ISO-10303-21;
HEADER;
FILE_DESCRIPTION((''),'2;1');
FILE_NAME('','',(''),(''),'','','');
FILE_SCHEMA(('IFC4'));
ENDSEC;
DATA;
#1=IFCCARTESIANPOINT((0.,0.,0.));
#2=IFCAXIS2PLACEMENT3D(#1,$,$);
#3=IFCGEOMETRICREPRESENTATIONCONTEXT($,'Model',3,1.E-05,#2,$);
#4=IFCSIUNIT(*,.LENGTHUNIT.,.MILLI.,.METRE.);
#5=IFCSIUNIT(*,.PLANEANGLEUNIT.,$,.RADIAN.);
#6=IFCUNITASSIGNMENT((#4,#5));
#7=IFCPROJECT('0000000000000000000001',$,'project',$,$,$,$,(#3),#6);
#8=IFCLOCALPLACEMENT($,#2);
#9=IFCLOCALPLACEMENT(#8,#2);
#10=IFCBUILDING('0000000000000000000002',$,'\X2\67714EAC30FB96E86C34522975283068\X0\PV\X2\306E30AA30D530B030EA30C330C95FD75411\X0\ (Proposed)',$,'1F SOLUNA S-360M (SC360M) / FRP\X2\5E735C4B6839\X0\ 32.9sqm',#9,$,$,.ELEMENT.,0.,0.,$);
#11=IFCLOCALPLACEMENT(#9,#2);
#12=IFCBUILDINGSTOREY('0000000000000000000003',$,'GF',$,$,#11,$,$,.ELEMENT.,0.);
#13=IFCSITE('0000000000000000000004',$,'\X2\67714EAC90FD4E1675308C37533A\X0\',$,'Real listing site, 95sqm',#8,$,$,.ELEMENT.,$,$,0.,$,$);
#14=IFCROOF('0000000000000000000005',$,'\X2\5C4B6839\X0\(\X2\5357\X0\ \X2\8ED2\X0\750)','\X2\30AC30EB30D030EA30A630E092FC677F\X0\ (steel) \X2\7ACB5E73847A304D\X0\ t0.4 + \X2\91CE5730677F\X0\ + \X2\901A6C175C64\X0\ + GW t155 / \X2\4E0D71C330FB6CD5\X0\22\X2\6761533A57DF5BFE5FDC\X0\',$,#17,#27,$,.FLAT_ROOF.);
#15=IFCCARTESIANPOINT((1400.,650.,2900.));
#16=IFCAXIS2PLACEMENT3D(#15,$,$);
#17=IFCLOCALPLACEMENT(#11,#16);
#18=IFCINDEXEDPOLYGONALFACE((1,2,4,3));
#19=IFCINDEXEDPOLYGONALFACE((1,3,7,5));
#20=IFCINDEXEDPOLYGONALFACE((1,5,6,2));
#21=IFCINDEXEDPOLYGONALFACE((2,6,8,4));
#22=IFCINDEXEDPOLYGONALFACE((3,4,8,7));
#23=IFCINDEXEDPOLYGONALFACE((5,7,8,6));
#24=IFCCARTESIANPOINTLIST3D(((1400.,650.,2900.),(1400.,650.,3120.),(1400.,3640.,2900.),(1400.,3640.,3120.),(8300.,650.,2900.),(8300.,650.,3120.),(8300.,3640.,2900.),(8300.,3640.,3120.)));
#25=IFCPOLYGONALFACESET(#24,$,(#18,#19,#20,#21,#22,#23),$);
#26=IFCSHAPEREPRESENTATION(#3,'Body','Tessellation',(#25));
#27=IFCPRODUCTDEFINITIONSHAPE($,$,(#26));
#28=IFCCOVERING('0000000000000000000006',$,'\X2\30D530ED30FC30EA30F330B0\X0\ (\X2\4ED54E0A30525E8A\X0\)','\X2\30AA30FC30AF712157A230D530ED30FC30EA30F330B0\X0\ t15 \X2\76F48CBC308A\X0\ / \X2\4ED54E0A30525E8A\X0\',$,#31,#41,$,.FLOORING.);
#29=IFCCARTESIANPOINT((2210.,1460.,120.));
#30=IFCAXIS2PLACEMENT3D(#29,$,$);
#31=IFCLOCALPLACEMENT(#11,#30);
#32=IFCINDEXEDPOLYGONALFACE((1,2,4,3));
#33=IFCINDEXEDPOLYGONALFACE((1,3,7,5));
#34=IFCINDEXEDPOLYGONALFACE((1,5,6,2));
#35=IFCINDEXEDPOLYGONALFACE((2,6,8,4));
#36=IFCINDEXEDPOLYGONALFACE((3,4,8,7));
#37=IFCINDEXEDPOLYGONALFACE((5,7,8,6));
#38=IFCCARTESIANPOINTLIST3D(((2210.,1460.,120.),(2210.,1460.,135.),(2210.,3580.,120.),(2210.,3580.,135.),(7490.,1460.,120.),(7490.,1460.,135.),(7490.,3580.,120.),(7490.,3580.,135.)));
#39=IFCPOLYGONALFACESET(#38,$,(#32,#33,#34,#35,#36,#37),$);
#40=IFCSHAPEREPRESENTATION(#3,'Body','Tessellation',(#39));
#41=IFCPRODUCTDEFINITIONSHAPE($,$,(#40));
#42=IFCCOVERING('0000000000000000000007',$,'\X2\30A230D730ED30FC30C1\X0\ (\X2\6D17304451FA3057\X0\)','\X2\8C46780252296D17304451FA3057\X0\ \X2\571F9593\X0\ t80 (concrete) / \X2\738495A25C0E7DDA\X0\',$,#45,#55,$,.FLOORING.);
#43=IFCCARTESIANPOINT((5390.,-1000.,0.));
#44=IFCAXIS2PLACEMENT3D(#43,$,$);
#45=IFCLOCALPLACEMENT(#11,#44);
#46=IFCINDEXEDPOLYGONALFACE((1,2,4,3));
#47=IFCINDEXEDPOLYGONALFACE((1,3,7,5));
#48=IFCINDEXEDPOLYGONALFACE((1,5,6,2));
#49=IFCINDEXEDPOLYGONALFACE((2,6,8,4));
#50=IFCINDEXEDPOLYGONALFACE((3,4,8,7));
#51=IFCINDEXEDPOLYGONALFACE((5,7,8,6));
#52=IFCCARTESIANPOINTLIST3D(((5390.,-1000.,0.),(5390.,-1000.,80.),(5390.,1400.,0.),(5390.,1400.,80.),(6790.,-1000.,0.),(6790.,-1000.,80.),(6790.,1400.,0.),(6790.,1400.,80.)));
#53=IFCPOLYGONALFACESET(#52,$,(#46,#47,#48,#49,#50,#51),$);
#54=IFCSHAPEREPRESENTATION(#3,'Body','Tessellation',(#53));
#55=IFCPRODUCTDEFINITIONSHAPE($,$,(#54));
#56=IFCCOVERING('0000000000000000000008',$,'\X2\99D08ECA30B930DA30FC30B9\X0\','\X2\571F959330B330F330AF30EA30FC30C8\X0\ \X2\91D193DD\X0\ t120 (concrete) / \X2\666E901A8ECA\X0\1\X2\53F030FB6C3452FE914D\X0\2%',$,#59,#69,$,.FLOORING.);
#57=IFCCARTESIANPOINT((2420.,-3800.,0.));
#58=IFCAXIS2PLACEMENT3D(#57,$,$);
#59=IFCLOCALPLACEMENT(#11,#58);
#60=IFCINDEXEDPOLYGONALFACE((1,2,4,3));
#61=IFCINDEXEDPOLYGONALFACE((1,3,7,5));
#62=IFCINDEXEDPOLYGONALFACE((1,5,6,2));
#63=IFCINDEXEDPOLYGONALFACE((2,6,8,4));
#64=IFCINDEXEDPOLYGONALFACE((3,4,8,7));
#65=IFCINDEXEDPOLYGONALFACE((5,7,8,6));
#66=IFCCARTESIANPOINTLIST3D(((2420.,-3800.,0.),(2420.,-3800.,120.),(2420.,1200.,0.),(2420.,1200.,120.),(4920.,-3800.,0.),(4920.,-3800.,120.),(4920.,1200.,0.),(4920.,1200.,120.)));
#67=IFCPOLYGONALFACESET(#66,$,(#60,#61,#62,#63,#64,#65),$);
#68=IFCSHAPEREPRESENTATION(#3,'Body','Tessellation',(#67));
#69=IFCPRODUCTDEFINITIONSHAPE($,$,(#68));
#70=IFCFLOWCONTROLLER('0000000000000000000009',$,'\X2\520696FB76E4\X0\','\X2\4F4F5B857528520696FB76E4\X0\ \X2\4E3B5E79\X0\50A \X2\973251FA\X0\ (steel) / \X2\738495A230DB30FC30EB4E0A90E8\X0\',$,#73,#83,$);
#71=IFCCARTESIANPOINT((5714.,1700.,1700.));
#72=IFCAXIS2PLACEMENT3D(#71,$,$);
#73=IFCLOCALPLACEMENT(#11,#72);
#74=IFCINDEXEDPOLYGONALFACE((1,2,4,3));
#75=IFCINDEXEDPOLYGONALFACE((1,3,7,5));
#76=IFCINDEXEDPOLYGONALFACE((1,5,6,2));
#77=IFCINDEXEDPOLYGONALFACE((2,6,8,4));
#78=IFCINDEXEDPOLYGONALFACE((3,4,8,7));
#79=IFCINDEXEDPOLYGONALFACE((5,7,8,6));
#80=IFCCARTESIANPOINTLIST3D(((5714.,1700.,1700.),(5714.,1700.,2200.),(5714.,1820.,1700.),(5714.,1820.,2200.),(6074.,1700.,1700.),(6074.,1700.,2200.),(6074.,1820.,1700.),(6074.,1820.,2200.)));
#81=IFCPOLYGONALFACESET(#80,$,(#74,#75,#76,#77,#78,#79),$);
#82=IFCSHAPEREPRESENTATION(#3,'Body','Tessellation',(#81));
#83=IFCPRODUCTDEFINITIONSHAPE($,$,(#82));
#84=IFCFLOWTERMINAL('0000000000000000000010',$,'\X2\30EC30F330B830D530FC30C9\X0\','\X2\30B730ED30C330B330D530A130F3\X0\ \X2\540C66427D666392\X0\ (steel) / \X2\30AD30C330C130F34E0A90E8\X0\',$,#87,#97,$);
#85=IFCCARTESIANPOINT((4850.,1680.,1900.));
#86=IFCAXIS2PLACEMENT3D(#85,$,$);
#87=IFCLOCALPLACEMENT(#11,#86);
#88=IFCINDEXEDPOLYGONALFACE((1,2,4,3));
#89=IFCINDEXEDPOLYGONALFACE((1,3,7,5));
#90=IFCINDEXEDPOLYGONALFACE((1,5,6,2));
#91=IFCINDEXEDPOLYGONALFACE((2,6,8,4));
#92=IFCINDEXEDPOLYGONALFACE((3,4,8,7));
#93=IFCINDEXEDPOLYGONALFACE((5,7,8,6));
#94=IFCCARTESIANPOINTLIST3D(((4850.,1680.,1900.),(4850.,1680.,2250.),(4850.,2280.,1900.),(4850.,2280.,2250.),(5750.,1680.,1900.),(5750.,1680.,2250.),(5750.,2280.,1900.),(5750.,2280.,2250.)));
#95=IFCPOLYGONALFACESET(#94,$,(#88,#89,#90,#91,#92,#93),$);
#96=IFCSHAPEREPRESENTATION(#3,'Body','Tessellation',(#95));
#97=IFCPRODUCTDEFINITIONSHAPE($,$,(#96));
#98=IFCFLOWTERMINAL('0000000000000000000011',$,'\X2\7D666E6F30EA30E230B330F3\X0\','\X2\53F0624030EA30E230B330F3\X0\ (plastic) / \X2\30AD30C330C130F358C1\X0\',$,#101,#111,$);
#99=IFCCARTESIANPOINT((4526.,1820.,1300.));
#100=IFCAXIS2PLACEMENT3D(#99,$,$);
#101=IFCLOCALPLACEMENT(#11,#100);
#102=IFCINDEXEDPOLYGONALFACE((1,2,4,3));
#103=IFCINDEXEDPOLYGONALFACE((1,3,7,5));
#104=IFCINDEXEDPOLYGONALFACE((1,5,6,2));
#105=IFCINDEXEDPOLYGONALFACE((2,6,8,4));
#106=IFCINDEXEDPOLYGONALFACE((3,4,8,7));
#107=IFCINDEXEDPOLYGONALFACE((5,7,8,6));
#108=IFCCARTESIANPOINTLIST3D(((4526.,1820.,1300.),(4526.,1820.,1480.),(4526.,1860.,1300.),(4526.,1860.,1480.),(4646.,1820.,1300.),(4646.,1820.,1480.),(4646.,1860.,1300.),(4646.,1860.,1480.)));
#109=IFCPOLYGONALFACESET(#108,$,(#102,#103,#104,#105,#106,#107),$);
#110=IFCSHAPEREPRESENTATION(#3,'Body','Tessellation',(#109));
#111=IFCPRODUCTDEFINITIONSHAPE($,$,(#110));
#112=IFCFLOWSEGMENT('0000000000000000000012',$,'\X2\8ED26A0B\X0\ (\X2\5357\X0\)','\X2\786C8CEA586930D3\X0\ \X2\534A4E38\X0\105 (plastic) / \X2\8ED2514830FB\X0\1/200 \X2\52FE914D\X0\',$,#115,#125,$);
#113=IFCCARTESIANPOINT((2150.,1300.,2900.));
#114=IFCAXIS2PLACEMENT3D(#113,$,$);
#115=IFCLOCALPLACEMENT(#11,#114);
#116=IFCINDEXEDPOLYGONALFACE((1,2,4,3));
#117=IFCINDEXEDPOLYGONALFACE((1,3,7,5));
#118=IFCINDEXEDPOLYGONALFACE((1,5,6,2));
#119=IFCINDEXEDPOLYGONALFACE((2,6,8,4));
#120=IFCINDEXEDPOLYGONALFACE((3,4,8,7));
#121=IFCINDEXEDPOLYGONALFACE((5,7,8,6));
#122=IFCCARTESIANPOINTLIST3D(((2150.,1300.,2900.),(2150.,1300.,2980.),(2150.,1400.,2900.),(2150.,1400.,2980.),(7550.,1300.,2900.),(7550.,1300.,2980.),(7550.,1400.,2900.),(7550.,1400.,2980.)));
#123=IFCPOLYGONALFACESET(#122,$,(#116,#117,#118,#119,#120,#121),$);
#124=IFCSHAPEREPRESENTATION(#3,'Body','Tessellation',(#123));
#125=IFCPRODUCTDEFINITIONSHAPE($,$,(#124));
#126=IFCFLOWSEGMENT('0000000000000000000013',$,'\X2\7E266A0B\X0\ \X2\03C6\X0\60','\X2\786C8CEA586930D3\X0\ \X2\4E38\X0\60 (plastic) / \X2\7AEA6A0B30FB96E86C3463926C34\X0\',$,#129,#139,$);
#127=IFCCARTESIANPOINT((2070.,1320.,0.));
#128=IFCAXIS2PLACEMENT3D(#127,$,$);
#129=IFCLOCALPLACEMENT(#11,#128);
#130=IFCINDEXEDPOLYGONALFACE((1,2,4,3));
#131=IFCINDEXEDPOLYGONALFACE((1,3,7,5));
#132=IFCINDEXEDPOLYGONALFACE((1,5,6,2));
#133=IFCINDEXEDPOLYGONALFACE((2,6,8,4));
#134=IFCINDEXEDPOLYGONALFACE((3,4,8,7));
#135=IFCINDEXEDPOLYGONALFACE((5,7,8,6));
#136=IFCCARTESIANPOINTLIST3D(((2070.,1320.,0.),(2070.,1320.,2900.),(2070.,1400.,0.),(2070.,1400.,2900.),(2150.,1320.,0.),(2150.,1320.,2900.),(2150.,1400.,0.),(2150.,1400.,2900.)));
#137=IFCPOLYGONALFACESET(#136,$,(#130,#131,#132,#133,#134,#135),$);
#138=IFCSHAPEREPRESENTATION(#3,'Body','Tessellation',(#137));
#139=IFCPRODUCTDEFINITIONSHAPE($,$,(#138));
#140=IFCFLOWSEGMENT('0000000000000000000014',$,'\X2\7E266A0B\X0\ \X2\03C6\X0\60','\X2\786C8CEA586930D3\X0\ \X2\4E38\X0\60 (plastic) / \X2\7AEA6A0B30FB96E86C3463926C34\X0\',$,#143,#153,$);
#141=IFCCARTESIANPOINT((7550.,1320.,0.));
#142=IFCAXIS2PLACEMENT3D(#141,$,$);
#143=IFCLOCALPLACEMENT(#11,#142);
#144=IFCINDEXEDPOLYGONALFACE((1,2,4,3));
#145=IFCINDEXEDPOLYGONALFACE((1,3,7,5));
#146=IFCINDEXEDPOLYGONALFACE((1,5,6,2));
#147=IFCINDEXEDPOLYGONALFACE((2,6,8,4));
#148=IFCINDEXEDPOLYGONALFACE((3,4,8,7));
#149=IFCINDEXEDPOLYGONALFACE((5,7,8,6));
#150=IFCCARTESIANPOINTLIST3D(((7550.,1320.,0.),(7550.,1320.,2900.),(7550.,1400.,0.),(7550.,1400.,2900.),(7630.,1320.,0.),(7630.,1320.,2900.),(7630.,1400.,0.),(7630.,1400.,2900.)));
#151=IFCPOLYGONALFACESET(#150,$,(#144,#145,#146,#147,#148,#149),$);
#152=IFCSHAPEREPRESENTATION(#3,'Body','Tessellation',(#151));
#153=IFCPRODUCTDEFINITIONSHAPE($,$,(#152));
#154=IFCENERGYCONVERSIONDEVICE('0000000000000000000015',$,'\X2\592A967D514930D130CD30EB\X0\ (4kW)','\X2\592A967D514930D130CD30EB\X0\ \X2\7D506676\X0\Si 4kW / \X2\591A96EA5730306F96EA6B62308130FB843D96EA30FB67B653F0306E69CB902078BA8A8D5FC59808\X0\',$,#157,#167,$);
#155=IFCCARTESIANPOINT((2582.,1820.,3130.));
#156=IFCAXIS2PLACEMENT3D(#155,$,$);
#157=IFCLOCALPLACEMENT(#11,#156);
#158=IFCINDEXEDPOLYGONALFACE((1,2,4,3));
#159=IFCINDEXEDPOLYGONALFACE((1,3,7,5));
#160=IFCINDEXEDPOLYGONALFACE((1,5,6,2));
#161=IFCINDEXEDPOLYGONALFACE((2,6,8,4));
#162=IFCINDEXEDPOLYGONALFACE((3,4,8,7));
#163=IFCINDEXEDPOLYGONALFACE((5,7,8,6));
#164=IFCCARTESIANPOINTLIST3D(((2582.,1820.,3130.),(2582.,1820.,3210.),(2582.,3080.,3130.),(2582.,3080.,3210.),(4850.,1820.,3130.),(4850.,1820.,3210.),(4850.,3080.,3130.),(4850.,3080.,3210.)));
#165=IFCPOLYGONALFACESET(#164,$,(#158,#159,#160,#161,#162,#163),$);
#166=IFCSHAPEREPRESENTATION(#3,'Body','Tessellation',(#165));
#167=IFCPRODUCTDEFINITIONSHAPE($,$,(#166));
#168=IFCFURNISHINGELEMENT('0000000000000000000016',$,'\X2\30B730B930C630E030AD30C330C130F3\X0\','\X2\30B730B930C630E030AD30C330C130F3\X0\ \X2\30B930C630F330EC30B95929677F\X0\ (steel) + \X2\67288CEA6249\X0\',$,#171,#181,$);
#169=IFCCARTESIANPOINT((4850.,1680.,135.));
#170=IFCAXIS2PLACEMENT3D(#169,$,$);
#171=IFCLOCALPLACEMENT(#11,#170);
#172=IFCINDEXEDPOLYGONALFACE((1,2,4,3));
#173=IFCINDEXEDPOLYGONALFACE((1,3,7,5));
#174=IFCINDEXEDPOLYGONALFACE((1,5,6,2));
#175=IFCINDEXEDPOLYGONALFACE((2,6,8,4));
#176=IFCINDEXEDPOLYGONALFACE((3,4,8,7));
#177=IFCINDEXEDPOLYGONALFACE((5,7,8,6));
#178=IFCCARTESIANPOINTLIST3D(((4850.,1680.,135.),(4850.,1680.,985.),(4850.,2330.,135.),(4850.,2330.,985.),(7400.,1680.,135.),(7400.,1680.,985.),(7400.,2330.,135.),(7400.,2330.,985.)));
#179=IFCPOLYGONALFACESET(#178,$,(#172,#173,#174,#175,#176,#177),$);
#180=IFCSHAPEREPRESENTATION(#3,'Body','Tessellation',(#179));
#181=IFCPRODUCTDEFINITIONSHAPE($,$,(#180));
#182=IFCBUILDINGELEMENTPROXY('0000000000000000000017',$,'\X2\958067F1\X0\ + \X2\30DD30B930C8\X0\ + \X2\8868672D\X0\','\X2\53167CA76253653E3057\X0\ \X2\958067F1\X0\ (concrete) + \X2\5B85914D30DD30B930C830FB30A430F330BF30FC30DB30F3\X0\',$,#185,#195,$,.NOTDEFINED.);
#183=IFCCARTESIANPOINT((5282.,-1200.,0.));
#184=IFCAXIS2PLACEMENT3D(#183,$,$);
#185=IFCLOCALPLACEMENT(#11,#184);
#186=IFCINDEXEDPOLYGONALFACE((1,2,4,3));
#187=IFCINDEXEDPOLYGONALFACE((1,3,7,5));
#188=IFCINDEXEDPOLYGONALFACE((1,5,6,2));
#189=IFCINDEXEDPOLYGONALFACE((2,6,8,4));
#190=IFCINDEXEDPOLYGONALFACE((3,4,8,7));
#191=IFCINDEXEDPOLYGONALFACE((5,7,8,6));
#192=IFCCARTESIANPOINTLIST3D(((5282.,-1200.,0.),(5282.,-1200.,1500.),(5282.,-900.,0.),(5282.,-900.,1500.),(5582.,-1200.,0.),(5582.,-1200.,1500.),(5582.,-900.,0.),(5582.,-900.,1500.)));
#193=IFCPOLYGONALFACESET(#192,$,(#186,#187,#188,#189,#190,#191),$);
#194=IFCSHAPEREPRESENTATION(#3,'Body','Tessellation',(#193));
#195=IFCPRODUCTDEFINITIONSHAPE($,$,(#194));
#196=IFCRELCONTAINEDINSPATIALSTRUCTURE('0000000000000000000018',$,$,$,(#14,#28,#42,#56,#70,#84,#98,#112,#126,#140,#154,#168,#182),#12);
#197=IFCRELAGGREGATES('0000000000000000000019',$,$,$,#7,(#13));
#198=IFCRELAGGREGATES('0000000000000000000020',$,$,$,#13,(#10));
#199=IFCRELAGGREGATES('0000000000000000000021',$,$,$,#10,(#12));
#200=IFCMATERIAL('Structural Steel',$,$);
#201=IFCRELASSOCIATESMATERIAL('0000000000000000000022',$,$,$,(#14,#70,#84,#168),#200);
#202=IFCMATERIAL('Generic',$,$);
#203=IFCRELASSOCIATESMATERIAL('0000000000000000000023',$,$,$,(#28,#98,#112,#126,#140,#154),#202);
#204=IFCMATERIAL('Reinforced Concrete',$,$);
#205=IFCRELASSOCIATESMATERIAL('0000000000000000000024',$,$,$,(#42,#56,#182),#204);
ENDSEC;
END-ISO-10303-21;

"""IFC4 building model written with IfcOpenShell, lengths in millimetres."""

from ifc_helpers import new_model, si_unit, frame, frame_2d, origin, place, context, project, spatial, rectangle, extrude, material, element, save


model = new_model("IFC4")

# Units and contexts
model_context = context("Model", 3, precision=1e-05, world=origin())
ifc_project = project(units=[si_unit("LENGTHUNIT", "METRE", prefix="MILLI"), si_unit("PLANEANGLEUNIT", "RADIAN")], contexts=[model_context])

# Site, building, storey
site_placement = place(None, origin())
site = spatial("IfcSite", under=ifc_project, at=site_placement, Name="東京都世田谷区", ObjectType="Real listing site, 95sqm", CompositionType="ELEMENT", RefElevation=0.0)
building_placement = place(site_placement, origin())
building = spatial("IfcBuilding", under=site, at=building_placement, Name="東京・雨水利用とPVのオフグリッド志向 (Proposed)", ObjectType="1F SOLUNA S-360M (SC360M) / FRP平屋根 32.9sqm", CompositionType="ELEMENT", ElevationOfRefHeight=0.0, ElevationOfTerrain=0.0)
storey_placement = place(building_placement, origin())
storey = spatial("IfcBuildingStorey", under=building, at=storey_placement, Name="GF", CompositionType="ELEMENT", Elevation=0.0)

# Shared definitions
ifc_material_1 = material(Name="Reinforced Concrete")

# Roof
ifc_material_2 = material(Name="Structural Steel")
roof_placement = place(storey_placement, frame((1400.0, 650.0, 2900.0)))
element("IfcRoof", 1, at=roof_placement, inside=storey, material=ifc_material_2, Name="屋根(南 軒750)", Description="ガルバリウム鋼板 (steel) 立平葺き t0.4 + 野地板 + 通気層 + GW t155 / 不燃・法22条区域対応", PredefinedType="FLAT_ROOF", context=model_context, shape_type="SweptSolid", body=[
    extrude(rectangle(XDim=6900.0, YDim=2990.0, at=frame_2d((3450.0, 1495.0))), frame((1400.0, 650.0, 2900.0)), (0.0, 0.0, 1.0), 220.0),
])

# Coverings
ifc_material_3 = material(Name="Generic")
covering_1_placement = place(storey_placement, frame((2210.0, 1460.0, 120.0)))
element("IfcCovering", 2, at=covering_1_placement, inside=storey, material=ifc_material_3, Name="フローリング (仕上げ床)", Description="オーク無垢フローリング t15 直貼り / 仕上げ床", PredefinedType="FLOORING", context=model_context, shape_type="SweptSolid", body=[
    extrude(rectangle(XDim=5280.0, YDim=2120.0, at=frame_2d((2640.0, 1060.0))), frame((2210.0, 1460.0, 120.0)), (0.0, 0.0, 1.0), 15.0),
])
covering_2_placement = place(storey_placement, frame((5390.0, -1000.0, 0.0)))
element("IfcCovering", 3, at=covering_2_placement, inside=storey, material=ifc_material_1, Name="アプローチ (洗い出し)", Description="豆砂利洗い出し 土間 t80 (concrete) / 玄関導線", PredefinedType="FLOORING", context=model_context, shape_type="SweptSolid", body=[
    extrude(rectangle(XDim=1400.0, YDim=2400.0, at=frame_2d((700.0, 1200.0))), frame((5390.0, -1000.0, 0.0)), (0.0, 0.0, 1.0), 80.0),
])
covering_3_placement = place(storey_placement, frame((2420.0, -3800.0, 0.0)))
element("IfcCovering", 4, at=covering_3_placement, inside=storey, material=ifc_material_1, Name="駐車スペース", Description="土間コンクリート 金鏝 t120 (concrete) / 普通車1台・水勾配2%", PredefinedType="FLOORING", context=model_context, shape_type="SweptSolid", body=[
    extrude(rectangle(XDim=2500.0, YDim=5000.0, at=frame_2d((1250.0, 2500.0))), frame((2420.0, -3800.0, 0.0)), (0.0, 0.0, 1.0), 120.0),
])

# Flow controller
flow_controller_placement = place(storey_placement, frame((5714.0, 1700.0, 1700.0)))
element("IfcFlowController", 5, at=flow_controller_placement, inside=storey, material=ifc_material_2, Name="分電盤", Description="住宅用分電盤 主幹50A 露出 (steel) / 玄関ホール上部", context=model_context, shape_type="SweptSolid", body=[
    extrude(rectangle(XDim=360.0, YDim=120.0, at=frame_2d((180.0, 60.0))), frame((5714.0, 1700.0, 1700.0)), (0.0, 0.0, 1.0), 500.0),
])

# Flow terminals
flow_terminal_1_placement = place(storey_placement, frame((4850.0, 1680.0, 1900.0)))
element("IfcFlowTerminal", 6, at=flow_terminal_1_placement, inside=storey, material=ifc_material_2, Name="レンジフード", Description="シロッコファン 同時給排 (steel) / キッチン上部", context=model_context, shape_type="SweptSolid", body=[
    extrude(rectangle(XDim=900.0, YDim=600.0, at=frame_2d((450.0, 300.0))), frame((4850.0, 1680.0, 1900.0)), (0.0, 0.0, 1.0), 350.0),
])
flow_terminal_2_placement = place(storey_placement, frame((4526.0, 1820.0, 1300.0)))
element("IfcFlowTerminal", 7, at=flow_terminal_2_placement, inside=storey, material=ifc_material_3, Name="給湯リモコン", Description="台所リモコン (plastic) / キッチン壁", context=model_context, shape_type="SweptSolid", body=[
    extrude(rectangle(XDim=120.0, YDim=40.0, at=frame_2d((60.0, 20.0))), frame((4526.0, 1820.0, 1300.0)), (0.0, 0.0, 1.0), 180.0),
])

# Flow segments
flow_segment_1_placement = place(storey_placement, frame((2150.0, 1300.0, 2900.0)))
element("IfcFlowSegment", 8, at=flow_segment_1_placement, inside=storey, material=ifc_material_3, Name="軒樋 (南)", Description="硬質塩ビ 半丸105 (plastic) / 軒先・1/200 勾配", context=model_context, shape_type="SweptSolid", body=[
    extrude(rectangle(XDim=5400.0, YDim=100.0, at=frame_2d((2700.0, 50.0))), frame((2150.0, 1300.0, 2900.0)), (0.0, 0.0, 1.0), 80.0),
])
flow_segment_2_placement = place(storey_placement, frame((2070.0, 1320.0, 0.0)))
element("IfcFlowSegment", 9, at=flow_segment_2_placement, inside=storey, material=ifc_material_3, Name="縦樋 φ60", Description="硬質塩ビ 丸60 (plastic) / 竪樋・雨水排水", context=model_context, shape_type="SweptSolid", body=[
    extrude(rectangle(XDim=80.0, YDim=80.0, at=frame_2d((40.0, 40.0))), frame((2070.0, 1320.0, 0.0)), (0.0, 0.0, 1.0), 2900.0),
])
flow_segment_3_placement = place(storey_placement, frame((7550.0, 1320.0, 0.0)))
element("IfcFlowSegment", 10, at=flow_segment_3_placement, inside=storey, material=ifc_material_3, Name="縦樋 φ60", Description="硬質塩ビ 丸60 (plastic) / 竪樋・雨水排水", context=model_context, shape_type="SweptSolid", body=[
    extrude(rectangle(XDim=80.0, YDim=80.0, at=frame_2d((40.0, 40.0))), frame((7550.0, 1320.0, 0.0)), (0.0, 0.0, 1.0), 2900.0),
])

# Energy conversion device
energy_conversion_device_placement = place(storey_placement, frame((2582.0, 1820.0, 3130.0)))
element("IfcEnergyConversionDevice", 11, at=energy_conversion_device_placement, inside=storey, material=ifc_material_3, Name="太陽光パネル (4kW)", Description="太陽光パネル 結晶Si 4kW / 多雪地は雪止め・落雪・架台の構造確認必須", context=model_context, shape_type="SweptSolid", body=[
    extrude(rectangle(XDim=2268.0, YDim=1260.0, at=frame_2d((1134.0, 630.0))), frame((2582.0, 1820.0, 3130.0)), (0.0, 0.0, 1.0), 80.0),
])

# Furnishing element
furnishing_placement = place(storey_placement, frame((4850.0, 1680.0, 135.0)))
element("IfcFurnishingElement", 12, at=furnishing_placement, inside=storey, material=ifc_material_2, Name="システムキッチン", Description="システムキッチン ステンレス天板 (steel) + 木質扉", context=model_context, shape_type="SweptSolid", body=[
    extrude(rectangle(XDim=2550.0, YDim=650.0, at=frame_2d((1275.0, 325.0))), frame((4850.0, 1680.0, 135.0)), (0.0, 0.0, 1.0), 850.0),
])

# Building element proxy
proxy_placement = place(storey_placement, frame((5282.0, -1200.0, 0.0)))
element("IfcBuildingElementProxy", 13, at=proxy_placement, inside=storey, material=ifc_material_1, Name="門柱 + ポスト + 表札", Description="化粧打放し 門柱 (concrete) + 宅配ポスト・インターホン", PredefinedType="NOTDEFINED", context=model_context, shape_type="SweptSolid", body=[
    extrude(rectangle(XDim=300.0, YDim=300.0, at=frame_2d((150.0, 150.0))), frame((5282.0, -1200.0, 0.0)), (0.0, 0.0, 1.0), 1500.0),
])

save(model, "model.ifc")
